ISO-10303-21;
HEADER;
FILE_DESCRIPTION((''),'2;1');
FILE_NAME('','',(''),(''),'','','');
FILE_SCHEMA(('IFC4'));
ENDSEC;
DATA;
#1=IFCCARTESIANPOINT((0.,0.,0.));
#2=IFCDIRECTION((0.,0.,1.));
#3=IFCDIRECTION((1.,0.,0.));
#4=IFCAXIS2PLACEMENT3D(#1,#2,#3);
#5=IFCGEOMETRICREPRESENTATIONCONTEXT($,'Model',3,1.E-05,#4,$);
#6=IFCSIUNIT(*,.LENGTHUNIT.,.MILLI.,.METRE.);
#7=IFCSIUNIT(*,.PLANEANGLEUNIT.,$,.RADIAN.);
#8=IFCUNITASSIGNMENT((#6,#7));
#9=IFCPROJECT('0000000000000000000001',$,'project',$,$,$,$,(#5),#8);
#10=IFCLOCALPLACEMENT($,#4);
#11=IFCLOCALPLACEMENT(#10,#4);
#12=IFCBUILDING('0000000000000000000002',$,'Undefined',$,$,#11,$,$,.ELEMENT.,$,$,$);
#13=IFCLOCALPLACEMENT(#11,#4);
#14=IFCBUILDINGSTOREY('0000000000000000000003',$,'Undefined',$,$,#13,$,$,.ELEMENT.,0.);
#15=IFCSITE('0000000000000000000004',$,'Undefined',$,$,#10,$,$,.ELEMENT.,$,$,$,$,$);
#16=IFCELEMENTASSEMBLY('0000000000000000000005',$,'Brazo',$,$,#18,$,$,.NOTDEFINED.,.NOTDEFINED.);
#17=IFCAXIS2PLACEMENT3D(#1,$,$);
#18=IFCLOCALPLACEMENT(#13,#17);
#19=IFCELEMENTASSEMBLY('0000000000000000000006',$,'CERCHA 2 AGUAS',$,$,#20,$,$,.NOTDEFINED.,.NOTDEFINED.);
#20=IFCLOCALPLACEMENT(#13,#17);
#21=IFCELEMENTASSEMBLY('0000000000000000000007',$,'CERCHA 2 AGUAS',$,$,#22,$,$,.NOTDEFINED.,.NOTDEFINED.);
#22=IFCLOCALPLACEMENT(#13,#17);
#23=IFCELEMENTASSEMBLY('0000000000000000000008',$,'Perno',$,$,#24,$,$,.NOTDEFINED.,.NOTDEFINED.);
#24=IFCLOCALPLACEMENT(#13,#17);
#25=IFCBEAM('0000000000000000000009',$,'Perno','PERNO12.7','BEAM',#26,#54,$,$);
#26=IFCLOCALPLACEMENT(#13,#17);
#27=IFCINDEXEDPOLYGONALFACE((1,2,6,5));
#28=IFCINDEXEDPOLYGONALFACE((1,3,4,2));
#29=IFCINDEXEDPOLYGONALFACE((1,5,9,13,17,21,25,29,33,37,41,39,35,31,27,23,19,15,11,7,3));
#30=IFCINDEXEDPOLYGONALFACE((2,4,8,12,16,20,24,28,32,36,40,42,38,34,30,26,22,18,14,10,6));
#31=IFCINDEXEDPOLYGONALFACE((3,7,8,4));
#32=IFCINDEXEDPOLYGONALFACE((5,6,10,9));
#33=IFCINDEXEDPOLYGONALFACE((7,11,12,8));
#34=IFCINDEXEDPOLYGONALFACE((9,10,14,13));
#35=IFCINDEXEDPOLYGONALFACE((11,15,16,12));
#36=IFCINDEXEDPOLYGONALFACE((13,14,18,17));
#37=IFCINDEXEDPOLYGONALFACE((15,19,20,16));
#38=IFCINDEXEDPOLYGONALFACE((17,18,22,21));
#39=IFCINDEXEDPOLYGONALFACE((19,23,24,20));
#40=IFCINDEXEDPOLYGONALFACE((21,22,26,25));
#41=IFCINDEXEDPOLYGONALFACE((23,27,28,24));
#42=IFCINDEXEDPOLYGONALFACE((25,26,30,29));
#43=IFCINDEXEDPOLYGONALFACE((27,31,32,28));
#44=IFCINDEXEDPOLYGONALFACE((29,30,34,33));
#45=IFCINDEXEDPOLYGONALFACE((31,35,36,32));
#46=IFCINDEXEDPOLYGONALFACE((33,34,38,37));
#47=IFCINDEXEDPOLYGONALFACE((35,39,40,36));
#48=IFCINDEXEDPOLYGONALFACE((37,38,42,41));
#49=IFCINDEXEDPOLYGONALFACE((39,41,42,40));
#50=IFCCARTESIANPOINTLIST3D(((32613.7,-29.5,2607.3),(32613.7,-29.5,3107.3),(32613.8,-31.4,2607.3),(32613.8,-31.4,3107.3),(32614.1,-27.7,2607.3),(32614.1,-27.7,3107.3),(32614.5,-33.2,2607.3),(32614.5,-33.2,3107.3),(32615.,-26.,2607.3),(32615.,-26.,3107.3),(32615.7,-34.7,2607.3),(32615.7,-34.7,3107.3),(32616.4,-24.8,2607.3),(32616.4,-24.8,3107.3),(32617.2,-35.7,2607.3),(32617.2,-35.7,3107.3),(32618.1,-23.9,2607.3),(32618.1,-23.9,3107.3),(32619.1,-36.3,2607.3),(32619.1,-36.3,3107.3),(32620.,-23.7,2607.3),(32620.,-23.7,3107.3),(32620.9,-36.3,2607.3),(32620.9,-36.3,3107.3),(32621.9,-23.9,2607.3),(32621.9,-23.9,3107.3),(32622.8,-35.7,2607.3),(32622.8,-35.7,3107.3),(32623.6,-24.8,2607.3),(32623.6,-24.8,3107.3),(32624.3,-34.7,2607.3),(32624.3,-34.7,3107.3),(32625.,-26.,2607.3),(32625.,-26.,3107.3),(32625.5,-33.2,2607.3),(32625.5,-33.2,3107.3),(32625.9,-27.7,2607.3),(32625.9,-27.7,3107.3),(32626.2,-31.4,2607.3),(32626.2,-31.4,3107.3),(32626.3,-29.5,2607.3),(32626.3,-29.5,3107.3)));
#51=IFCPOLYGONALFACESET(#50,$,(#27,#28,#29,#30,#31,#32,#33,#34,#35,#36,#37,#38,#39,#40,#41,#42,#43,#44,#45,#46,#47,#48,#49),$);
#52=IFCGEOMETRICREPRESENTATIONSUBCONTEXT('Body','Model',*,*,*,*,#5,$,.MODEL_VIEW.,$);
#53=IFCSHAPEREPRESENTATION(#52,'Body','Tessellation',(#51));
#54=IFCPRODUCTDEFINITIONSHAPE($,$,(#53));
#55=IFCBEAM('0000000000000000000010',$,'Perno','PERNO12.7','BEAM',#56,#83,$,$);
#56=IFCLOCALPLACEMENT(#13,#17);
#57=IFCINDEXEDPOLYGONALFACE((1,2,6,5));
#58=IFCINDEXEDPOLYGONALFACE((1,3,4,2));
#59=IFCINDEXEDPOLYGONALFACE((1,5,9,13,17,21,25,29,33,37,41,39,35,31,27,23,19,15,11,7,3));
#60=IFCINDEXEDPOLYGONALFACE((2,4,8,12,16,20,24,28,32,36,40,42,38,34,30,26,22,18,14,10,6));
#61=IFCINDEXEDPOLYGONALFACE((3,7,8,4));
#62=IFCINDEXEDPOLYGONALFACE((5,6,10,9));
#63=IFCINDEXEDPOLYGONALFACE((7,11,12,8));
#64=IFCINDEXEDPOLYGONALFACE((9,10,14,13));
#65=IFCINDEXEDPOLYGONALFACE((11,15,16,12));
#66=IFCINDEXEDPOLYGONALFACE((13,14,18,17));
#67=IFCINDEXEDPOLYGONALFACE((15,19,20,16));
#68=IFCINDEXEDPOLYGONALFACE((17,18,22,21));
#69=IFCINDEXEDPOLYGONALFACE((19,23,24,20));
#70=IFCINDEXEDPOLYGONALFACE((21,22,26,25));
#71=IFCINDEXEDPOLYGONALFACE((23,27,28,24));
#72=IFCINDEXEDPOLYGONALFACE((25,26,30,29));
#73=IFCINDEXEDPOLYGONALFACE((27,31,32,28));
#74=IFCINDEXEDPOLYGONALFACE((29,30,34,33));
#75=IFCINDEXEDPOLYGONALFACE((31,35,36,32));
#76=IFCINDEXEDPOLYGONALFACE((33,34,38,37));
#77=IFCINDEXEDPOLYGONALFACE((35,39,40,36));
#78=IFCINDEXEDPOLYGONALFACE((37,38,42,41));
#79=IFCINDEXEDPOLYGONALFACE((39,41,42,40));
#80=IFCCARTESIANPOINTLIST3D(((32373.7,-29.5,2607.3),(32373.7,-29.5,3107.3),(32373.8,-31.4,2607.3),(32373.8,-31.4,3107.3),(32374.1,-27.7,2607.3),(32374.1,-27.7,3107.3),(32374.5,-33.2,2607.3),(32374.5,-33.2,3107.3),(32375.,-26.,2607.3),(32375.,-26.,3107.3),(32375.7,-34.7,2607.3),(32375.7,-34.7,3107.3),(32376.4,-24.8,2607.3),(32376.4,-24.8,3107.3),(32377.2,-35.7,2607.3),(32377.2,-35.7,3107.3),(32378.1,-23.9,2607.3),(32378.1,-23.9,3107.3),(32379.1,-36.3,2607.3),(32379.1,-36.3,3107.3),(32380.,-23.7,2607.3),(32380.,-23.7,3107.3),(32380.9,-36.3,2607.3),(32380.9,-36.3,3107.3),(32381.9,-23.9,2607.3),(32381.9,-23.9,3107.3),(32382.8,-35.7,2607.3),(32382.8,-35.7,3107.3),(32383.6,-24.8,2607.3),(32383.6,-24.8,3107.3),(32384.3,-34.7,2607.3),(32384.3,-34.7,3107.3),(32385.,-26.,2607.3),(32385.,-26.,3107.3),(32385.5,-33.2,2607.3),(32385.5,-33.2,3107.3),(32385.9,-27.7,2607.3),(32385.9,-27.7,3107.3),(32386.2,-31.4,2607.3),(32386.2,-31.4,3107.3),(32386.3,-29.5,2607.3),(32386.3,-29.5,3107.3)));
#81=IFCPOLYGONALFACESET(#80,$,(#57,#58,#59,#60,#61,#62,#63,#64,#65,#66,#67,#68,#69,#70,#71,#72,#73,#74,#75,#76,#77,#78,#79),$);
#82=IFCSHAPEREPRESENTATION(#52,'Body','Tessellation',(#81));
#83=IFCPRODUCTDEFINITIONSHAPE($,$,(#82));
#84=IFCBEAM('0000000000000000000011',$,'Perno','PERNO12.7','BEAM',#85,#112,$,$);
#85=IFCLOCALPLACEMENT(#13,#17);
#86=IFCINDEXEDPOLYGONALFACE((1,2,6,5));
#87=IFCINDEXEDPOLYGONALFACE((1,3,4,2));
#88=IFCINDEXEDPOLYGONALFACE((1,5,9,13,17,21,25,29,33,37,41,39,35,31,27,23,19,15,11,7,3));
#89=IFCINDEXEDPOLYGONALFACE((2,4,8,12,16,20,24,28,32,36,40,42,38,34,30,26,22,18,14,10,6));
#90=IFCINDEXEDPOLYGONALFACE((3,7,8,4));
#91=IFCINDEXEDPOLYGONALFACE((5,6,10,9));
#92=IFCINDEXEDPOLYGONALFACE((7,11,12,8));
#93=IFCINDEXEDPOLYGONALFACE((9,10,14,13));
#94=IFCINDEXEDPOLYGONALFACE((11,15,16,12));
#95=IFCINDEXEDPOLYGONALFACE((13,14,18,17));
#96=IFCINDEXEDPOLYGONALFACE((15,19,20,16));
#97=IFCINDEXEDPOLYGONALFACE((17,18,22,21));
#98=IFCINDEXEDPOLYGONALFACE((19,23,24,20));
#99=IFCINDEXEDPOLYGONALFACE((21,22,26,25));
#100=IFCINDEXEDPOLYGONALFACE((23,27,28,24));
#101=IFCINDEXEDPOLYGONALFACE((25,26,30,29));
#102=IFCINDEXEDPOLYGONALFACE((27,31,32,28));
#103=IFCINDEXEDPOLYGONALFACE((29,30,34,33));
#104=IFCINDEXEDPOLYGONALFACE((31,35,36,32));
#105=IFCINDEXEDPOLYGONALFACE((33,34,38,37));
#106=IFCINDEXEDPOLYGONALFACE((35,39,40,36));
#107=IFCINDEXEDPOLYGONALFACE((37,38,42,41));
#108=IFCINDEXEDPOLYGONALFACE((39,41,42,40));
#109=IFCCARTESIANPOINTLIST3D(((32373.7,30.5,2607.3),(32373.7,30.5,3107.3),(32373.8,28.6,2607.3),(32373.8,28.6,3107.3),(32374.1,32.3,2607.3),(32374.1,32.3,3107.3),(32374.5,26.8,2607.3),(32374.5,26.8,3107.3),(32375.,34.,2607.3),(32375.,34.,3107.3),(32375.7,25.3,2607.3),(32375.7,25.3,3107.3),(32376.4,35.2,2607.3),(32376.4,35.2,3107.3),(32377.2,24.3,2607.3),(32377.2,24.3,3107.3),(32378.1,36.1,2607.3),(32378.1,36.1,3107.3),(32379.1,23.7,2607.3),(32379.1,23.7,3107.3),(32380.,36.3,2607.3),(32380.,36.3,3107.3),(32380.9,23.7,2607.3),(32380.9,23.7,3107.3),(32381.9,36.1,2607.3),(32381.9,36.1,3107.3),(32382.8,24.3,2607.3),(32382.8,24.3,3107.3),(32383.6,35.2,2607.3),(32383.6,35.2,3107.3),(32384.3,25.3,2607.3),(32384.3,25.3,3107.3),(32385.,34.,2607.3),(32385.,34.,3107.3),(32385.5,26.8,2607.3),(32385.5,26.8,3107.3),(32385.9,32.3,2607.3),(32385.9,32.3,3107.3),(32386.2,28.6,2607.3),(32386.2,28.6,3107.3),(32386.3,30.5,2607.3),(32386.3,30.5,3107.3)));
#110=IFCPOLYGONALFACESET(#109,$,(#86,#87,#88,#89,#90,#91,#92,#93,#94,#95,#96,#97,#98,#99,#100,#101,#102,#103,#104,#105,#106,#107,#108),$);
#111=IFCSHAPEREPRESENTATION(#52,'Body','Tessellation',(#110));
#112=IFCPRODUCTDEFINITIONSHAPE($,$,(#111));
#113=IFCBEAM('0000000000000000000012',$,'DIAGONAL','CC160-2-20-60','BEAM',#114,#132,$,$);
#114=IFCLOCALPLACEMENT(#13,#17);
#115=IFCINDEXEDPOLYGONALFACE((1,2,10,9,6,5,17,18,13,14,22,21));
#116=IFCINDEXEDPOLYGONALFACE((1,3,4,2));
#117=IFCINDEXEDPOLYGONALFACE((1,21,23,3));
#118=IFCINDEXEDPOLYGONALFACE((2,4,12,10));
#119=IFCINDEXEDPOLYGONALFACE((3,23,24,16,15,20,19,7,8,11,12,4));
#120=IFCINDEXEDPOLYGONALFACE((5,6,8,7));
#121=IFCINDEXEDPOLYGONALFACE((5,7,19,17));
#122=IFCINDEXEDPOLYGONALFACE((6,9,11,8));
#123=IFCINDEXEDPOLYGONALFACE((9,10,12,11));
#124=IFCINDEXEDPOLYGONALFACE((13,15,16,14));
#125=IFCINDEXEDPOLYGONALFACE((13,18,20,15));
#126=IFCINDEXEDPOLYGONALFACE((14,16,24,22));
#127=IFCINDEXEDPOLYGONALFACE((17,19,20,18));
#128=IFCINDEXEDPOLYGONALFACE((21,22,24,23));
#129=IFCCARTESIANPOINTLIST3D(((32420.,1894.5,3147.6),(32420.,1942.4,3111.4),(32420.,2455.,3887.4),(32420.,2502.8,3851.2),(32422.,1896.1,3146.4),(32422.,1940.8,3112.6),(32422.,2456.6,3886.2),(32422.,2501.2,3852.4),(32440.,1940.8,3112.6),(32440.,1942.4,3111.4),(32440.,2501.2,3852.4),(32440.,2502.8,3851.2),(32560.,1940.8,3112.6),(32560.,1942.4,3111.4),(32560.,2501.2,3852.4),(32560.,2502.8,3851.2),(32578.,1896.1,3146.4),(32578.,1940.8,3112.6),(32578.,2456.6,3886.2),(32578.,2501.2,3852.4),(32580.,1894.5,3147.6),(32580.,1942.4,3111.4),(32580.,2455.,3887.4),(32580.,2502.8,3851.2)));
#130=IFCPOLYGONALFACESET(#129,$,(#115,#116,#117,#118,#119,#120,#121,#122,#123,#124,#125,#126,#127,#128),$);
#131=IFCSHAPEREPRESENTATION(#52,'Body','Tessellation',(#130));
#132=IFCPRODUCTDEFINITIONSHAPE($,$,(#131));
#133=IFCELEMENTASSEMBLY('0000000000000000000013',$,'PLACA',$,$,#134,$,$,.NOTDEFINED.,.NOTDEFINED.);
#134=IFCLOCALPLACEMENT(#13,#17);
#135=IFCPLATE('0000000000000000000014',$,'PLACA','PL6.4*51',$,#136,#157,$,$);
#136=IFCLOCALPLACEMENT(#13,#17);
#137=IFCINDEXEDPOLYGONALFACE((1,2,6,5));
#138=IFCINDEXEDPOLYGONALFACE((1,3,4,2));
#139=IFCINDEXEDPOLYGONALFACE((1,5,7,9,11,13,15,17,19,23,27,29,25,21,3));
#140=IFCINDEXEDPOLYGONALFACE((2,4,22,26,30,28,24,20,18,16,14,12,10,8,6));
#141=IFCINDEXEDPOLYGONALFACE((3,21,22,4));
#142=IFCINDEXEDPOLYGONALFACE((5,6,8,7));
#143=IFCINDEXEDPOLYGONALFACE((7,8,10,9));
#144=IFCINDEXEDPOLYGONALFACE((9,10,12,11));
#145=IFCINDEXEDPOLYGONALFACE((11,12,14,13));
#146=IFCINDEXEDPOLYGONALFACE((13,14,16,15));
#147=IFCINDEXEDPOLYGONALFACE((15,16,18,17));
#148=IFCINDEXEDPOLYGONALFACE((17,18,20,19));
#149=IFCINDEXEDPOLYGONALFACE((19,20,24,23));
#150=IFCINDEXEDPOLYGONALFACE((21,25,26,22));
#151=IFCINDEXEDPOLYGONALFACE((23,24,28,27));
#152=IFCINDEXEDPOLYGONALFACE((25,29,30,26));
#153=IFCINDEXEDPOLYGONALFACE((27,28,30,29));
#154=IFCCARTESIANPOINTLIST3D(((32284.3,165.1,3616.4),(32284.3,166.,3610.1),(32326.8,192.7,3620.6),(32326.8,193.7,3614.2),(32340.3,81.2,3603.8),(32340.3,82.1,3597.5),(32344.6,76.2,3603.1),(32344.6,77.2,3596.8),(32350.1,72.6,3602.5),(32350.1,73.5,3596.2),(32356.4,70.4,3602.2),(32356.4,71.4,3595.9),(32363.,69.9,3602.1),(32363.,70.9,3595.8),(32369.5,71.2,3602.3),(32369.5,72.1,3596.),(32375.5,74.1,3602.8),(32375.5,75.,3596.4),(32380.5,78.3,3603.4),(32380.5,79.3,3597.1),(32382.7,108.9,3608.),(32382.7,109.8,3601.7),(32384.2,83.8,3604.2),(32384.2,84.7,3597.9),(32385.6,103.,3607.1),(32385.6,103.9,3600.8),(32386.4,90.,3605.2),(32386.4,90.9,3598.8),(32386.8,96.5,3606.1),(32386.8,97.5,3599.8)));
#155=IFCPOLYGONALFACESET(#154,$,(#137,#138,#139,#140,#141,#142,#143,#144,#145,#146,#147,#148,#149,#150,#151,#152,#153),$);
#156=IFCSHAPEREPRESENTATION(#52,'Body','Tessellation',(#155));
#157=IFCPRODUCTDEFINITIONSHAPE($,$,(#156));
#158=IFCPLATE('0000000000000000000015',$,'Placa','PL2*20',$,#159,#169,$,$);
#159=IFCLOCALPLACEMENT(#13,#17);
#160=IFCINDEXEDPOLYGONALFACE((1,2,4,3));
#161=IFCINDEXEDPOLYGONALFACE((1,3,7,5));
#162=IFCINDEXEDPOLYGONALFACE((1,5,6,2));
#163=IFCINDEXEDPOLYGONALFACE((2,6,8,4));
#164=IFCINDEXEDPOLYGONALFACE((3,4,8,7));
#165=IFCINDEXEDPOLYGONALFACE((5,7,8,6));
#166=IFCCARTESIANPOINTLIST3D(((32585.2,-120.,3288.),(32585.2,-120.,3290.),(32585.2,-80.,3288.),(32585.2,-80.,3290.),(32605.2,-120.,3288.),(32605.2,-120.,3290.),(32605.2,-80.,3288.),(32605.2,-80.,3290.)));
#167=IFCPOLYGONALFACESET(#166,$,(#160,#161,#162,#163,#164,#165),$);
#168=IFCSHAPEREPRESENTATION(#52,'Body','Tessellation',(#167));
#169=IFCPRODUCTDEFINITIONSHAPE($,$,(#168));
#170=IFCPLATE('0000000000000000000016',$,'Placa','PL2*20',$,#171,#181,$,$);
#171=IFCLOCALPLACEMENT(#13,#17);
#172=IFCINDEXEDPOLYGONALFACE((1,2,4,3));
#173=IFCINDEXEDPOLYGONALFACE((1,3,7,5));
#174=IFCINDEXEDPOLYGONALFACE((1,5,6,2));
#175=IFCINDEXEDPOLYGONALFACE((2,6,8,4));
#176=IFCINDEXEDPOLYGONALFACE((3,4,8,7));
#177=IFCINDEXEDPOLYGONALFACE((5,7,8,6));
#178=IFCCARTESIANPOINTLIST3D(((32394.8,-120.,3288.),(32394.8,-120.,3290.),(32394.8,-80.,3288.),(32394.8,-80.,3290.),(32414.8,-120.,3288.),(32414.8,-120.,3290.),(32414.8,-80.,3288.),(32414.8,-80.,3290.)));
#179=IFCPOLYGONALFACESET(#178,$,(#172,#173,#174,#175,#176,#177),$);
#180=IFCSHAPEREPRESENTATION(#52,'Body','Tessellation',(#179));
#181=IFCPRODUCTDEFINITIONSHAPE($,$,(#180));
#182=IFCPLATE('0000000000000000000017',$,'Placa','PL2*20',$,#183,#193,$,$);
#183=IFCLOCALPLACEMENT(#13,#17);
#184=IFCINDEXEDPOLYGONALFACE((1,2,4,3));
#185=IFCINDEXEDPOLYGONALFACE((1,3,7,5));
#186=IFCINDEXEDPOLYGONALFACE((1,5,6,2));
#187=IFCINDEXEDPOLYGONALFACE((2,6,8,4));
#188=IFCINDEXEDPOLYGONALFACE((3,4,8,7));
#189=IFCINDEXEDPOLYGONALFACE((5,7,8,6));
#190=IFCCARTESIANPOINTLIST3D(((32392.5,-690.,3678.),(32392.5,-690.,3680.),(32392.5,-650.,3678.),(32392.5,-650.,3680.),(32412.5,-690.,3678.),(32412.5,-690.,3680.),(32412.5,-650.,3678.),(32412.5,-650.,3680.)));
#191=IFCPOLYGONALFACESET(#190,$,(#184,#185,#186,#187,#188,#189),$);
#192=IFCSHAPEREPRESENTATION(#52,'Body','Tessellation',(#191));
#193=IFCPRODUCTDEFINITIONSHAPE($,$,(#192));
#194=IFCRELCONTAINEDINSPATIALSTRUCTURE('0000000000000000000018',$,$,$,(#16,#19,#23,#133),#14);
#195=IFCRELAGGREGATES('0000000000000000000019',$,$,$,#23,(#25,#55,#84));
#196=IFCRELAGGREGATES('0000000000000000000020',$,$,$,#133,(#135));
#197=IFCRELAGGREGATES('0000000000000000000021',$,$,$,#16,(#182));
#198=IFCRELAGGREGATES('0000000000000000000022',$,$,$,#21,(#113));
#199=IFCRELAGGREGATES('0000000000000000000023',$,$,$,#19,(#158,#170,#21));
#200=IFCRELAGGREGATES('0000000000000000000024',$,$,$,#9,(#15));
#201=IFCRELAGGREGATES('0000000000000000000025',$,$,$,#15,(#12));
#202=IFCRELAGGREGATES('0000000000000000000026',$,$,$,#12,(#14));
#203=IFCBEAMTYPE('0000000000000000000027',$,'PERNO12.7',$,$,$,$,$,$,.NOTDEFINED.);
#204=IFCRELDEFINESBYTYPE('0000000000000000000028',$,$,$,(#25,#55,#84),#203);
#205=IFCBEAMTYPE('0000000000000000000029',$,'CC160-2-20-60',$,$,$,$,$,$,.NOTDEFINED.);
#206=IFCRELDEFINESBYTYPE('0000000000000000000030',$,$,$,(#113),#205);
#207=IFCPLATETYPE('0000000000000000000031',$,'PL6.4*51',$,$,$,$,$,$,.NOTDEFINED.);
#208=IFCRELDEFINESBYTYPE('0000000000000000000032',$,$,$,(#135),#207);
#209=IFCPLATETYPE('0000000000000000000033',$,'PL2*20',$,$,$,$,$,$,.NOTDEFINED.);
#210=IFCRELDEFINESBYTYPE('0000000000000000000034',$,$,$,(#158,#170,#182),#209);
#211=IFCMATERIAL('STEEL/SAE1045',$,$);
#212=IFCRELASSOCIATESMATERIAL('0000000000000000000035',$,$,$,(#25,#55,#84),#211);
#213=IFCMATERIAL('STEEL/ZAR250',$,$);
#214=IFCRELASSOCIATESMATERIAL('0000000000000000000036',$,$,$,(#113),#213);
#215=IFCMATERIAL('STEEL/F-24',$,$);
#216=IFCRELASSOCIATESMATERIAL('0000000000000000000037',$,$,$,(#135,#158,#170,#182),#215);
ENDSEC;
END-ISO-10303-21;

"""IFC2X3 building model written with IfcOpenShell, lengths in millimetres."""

from ifc_helpers import new_model, si_unit, frame, frame_2d, origin_with_axes, origin_2d_with_axis, place, context, subcontext, project, spatial, polyline, circle_curve, parameter, trimmed, segment, composite_curve, circle, c_section, outline, extrude, material, type_object, element, aggregate, save


model = new_model("IFC2X3")

# Units and contexts
model_context = context("Model", 3, precision=1e-05, world=origin_with_axes())
body_context = subcontext(model_context, "Body", "Model", "MODEL_VIEW")
ifc_project = project(units=[si_unit("LENGTHUNIT", "METRE", prefix="MILLI"), si_unit("PLANEANGLEUNIT", "RADIAN")], contexts=[model_context])

# Site, building, storey
site_placement = place(None, origin_with_axes())
site = spatial("IfcSite", under=ifc_project, at=site_placement, Name="Undefined", CompositionType="ELEMENT")
building_placement = place(site_placement, origin_with_axes())
building = spatial("IfcBuilding", under=site, at=building_placement, Name="Undefined", CompositionType="ELEMENT")
storey_placement = place(building_placement, origin_with_axes())
storey = spatial("IfcBuildingStorey", under=building, at=storey_placement, Name="Undefined", CompositionType="ELEMENT", Elevation=0.0)

# Element assembly
assembly_1_placement = place(storey_placement, origin_with_axes())
assembly_1 = element("IfcElementAssembly", 1, at=assembly_1_placement, inside=storey, Name="Brazo", AssemblyPlace="NOTDEFINED", PredefinedType="NOTDEFINED")
ifc_material_1 = material(Name="STEEL/ZAR250")

# Element assemblies
assembly_2_placement = place(storey_placement, origin_with_axes())
assembly_2 = element("IfcElementAssembly", 2, at=assembly_2_placement, inside=storey, Name="CERCHA 2 AGUAS", AssemblyPlace="NOTDEFINED", PredefinedType="NOTDEFINED")
assembly_3_placement = place(assembly_2_placement, origin_with_axes())
assembly_3 = element("IfcElementAssembly", 3, at=assembly_3_placement, Name="CERCHA 2 AGUAS", AssemblyPlace="NOTDEFINED", PredefinedType="NOTDEFINED")

# Element assembly, beams
assembly_4_placement = place(storey_placement, origin_with_axes())
assembly_4 = element("IfcElementAssembly", 4, at=assembly_4_placement, inside=storey, Name="Perno", AssemblyPlace="NOTDEFINED", PredefinedType="NOTDEFINED")
ifc_material_2 = material(Name="STEEL/SAE1045")
beam_type_1 = type_object("IfcBeamType", Name="PERNO12.7", PredefinedType="NOTDEFINED")
beam_1_placement = place(assembly_4_placement, frame((32620.0, -30.0, 3107.3), z_axis=(-1.0, 0.0, 0.0), x_axis=(0.0, 0.0, -1.0)))
beam_1 = element("IfcBeam", 5, at=beam_1_placement, type_object=beam_type_1, material=ifc_material_2, Name="Perno", Description="PERNO12.7", ObjectType="BEAM", context=body_context, shape_type="SweptSolid", body=[
    extrude(circle(Radius=6.3, at=origin_2d_with_axis()), frame((500.0, 0.0, 0.0), z_axis=(-1.0, 0.0, 0.0), x_axis=(0.0, -1.0, 0.0)), (0.0, 0.0, 1.0), 500.0),
])
beam_2_placement = place(assembly_4_placement, frame((32380.0, -30.0, 3107.3), z_axis=(-1.0, 0.0, 0.0), x_axis=(0.0, 0.0, -1.0)))
beam_2 = element("IfcBeam", 6, at=beam_2_placement, type_object=beam_type_1, material=ifc_material_2, Name="Perno", Description="PERNO12.7", ObjectType="BEAM", context=body_context, shape_type="SweptSolid", body=[
    extrude(circle(Radius=6.3, at=origin_2d_with_axis()), frame((500.0, 0.0, 0.0), z_axis=(-1.0, 0.0, 0.0), x_axis=(0.0, -1.0, 0.0)), (0.0, 0.0, 1.0), 500.0),
])
beam_3_placement = place(assembly_4_placement, frame((32380.0, 30.0, 3107.3), z_axis=(-1.0, 0.0, 0.0), x_axis=(0.0, 0.0, -1.0)))
beam_3 = element("IfcBeam", 7, at=beam_3_placement, type_object=beam_type_1, material=ifc_material_2, Name="Perno", Description="PERNO12.7", ObjectType="BEAM", context=body_context, shape_type="SweptSolid", body=[
    extrude(circle(Radius=6.3, at=origin_2d_with_axis()), frame((500.0, 0.0, 0.0), z_axis=(-1.0, 0.0, 0.0), x_axis=(0.0, -1.0, 0.0)), (0.0, 0.0, 1.0), 500.0),
])
aggregate(assembly_4, [beam_1, beam_2, beam_3])

# Beam
beam_type_2 = type_object("IfcBeamType", Name="CC160-2-20-60", PredefinedType="NOTDEFINED")
beam_4_placement = place(assembly_3_placement, frame((32500.0, 1918.5, 3129.5), z_axis=(1.0, 0.0, 0.0), x_axis=(0.0, 0.603858, 0.797092)))
beam_4 = element("IfcBeam", 8, at=beam_4_placement, type_object=beam_type_2, material=ifc_material_1, Name="DIAGONAL", Description="CC160-2-20-60", ObjectType="BEAM", context=body_context, shape_type="SweptSolid", body=[
    extrude(c_section(Depth=160.0, Width=60.0, WallThickness=2.0, Girth=20.0, at=origin_2d_with_axis()), frame((928.1, 0.0, 0.0), z_axis=(-1.0, 0.0, 0.0), x_axis=(0.0, -1.0, 0.0)), (0.0, 0.0, 1.0), 928.1),
])

# Element assembly, plate
assembly_5_placement = place(storey_placement, origin_with_axes())
assembly_5 = element("IfcElementAssembly", 9, at=assembly_5_placement, inside=storey, Name="PLACA", AssemblyPlace="NOTDEFINED", PredefinedType="NOTDEFINED")
ifc_material_3 = material(Name="STEEL/F-24")
plate_type_1 = type_object("IfcPlateType", Name="PL6.4*51", PredefinedType="NOTDEFINED")
plate_1_placement = place(assembly_5_placement, frame((32396.7, 88.4, 3601.7), z_axis=(-0.00002, 0.148374, -0.988931), x_axis=(-0.834881, -0.544341, -0.081653)))
plate_1 = element("IfcPlate", 10, at=plate_1_placement, type_object=plate_type_1, material=ifc_material_3, Name="PLACA", Description="PL6.4*51", context=body_context, shape_type="SweptSolid", body=[
    extrude(outline(composite_curve([segment(trimmed(circle_curve(frame_2d((25.4, 25.4), x_axis=(-1.0, 0.0)), 25.4), [parameter(0.0)], [parameter(1.570796)], True, "PARAMETER"), True, "CONTINUOUS"), segment(polyline([(25.4, 0.0), (25.4, 0.0)]), True, "CONTINUOUS"), segment(trimmed(circle_curve(frame_2d((25.4, 25.4), x_axis=(0.0, -1.0)), 25.4), [parameter(0.0)], [parameter(1.570797)], True, "PARAMETER"), True, "CONTINUOUS"), segment(polyline([(50.8, 25.4), (50.8, 127.0), (0.0, 127.0), (0.0, 25.4)]), True, "CONTINUOUS")], self_intersect=True)), frame((0.0, 0.0, -3.2), z_axis=(0.0, 0.0, 1.0), x_axis=(1.0, 0.0, 0.0)), (0.0, 0.0, 1.0), 6.4),
])
aggregate(assembly_5, [plate_1])

# Plates
plate_type_2 = type_object("IfcPlateType", Name="PL2*20", PredefinedType="NOTDEFINED")
plate_2_placement = place(assembly_2_placement, frame((32605.2, -120.0, 3289.0), z_axis=(0.0, -0.000121, 1.0), x_axis=(0.000085, 1.0, 0.000121)))
plate_2 = element("IfcPlate", 11, at=plate_2_placement, type_object=plate_type_2, material=ifc_material_3, Name="Placa", Description="PL2*20", context=body_context, shape_type="SweptSolid", body=[
    extrude(outline(polyline([(0.0, 0.0), (40.0, 0.0), (40.0, 20.0), (0.0, 20.0), (0.0, 0.0)])), frame((0.0, 0.0, -1.0), z_axis=(0.0, 0.0, 1.0), x_axis=(1.0, 0.0, 0.0)), (0.0, 0.0, 1.0), 2.0),
])
plate_3_placement = place(assembly_2_placement, frame((32414.8, -120.0, 3289.0), z_axis=(0.0, -0.000121, 1.0), x_axis=(0.000085, 1.0, 0.000121)))
plate_3 = element("IfcPlate", 12, at=plate_3_placement, type_object=plate_type_2, material=ifc_material_3, Name="Placa", Description="PL2*20", context=body_context, shape_type="SweptSolid", body=[
    extrude(outline(polyline([(0.0, 0.0), (40.0, 0.0), (40.0, 20.0), (0.0, 20.0), (0.0, 0.0)])), frame((0.0, 0.0, -1.0), z_axis=(0.0, 0.0, 1.0), x_axis=(1.0, 0.0, 0.0)), (0.0, 0.0, 1.0), 2.0),
])
plate_4_placement = place(assembly_1_placement, frame((32412.5, -690.0, 3679.0), z_axis=(0.0, -0.000121, 1.0), x_axis=(0.000085, 1.0, 0.000121)))
plate_4 = element("IfcPlate", 13, at=plate_4_placement, type_object=plate_type_2, material=ifc_material_3, Name="Placa", Description="PL2*20", context=body_context, shape_type="SweptSolid", body=[
    extrude(outline(polyline([(0.0, 0.0), (40.0, 0.0), (40.0, 20.0), (0.0, 20.0), (0.0, 0.0)])), frame((0.0, 0.0, -1.0), z_axis=(0.0, 0.0, 1.0), x_axis=(1.0, 0.0, 0.0)), (0.0, 0.0, 1.0), 2.0),
])
aggregate(assembly_1, [plate_4])

aggregate(assembly_3, [beam_4])
aggregate(assembly_2, [plate_2, plate_3, assembly_3])

save(model, "model.ifc")
